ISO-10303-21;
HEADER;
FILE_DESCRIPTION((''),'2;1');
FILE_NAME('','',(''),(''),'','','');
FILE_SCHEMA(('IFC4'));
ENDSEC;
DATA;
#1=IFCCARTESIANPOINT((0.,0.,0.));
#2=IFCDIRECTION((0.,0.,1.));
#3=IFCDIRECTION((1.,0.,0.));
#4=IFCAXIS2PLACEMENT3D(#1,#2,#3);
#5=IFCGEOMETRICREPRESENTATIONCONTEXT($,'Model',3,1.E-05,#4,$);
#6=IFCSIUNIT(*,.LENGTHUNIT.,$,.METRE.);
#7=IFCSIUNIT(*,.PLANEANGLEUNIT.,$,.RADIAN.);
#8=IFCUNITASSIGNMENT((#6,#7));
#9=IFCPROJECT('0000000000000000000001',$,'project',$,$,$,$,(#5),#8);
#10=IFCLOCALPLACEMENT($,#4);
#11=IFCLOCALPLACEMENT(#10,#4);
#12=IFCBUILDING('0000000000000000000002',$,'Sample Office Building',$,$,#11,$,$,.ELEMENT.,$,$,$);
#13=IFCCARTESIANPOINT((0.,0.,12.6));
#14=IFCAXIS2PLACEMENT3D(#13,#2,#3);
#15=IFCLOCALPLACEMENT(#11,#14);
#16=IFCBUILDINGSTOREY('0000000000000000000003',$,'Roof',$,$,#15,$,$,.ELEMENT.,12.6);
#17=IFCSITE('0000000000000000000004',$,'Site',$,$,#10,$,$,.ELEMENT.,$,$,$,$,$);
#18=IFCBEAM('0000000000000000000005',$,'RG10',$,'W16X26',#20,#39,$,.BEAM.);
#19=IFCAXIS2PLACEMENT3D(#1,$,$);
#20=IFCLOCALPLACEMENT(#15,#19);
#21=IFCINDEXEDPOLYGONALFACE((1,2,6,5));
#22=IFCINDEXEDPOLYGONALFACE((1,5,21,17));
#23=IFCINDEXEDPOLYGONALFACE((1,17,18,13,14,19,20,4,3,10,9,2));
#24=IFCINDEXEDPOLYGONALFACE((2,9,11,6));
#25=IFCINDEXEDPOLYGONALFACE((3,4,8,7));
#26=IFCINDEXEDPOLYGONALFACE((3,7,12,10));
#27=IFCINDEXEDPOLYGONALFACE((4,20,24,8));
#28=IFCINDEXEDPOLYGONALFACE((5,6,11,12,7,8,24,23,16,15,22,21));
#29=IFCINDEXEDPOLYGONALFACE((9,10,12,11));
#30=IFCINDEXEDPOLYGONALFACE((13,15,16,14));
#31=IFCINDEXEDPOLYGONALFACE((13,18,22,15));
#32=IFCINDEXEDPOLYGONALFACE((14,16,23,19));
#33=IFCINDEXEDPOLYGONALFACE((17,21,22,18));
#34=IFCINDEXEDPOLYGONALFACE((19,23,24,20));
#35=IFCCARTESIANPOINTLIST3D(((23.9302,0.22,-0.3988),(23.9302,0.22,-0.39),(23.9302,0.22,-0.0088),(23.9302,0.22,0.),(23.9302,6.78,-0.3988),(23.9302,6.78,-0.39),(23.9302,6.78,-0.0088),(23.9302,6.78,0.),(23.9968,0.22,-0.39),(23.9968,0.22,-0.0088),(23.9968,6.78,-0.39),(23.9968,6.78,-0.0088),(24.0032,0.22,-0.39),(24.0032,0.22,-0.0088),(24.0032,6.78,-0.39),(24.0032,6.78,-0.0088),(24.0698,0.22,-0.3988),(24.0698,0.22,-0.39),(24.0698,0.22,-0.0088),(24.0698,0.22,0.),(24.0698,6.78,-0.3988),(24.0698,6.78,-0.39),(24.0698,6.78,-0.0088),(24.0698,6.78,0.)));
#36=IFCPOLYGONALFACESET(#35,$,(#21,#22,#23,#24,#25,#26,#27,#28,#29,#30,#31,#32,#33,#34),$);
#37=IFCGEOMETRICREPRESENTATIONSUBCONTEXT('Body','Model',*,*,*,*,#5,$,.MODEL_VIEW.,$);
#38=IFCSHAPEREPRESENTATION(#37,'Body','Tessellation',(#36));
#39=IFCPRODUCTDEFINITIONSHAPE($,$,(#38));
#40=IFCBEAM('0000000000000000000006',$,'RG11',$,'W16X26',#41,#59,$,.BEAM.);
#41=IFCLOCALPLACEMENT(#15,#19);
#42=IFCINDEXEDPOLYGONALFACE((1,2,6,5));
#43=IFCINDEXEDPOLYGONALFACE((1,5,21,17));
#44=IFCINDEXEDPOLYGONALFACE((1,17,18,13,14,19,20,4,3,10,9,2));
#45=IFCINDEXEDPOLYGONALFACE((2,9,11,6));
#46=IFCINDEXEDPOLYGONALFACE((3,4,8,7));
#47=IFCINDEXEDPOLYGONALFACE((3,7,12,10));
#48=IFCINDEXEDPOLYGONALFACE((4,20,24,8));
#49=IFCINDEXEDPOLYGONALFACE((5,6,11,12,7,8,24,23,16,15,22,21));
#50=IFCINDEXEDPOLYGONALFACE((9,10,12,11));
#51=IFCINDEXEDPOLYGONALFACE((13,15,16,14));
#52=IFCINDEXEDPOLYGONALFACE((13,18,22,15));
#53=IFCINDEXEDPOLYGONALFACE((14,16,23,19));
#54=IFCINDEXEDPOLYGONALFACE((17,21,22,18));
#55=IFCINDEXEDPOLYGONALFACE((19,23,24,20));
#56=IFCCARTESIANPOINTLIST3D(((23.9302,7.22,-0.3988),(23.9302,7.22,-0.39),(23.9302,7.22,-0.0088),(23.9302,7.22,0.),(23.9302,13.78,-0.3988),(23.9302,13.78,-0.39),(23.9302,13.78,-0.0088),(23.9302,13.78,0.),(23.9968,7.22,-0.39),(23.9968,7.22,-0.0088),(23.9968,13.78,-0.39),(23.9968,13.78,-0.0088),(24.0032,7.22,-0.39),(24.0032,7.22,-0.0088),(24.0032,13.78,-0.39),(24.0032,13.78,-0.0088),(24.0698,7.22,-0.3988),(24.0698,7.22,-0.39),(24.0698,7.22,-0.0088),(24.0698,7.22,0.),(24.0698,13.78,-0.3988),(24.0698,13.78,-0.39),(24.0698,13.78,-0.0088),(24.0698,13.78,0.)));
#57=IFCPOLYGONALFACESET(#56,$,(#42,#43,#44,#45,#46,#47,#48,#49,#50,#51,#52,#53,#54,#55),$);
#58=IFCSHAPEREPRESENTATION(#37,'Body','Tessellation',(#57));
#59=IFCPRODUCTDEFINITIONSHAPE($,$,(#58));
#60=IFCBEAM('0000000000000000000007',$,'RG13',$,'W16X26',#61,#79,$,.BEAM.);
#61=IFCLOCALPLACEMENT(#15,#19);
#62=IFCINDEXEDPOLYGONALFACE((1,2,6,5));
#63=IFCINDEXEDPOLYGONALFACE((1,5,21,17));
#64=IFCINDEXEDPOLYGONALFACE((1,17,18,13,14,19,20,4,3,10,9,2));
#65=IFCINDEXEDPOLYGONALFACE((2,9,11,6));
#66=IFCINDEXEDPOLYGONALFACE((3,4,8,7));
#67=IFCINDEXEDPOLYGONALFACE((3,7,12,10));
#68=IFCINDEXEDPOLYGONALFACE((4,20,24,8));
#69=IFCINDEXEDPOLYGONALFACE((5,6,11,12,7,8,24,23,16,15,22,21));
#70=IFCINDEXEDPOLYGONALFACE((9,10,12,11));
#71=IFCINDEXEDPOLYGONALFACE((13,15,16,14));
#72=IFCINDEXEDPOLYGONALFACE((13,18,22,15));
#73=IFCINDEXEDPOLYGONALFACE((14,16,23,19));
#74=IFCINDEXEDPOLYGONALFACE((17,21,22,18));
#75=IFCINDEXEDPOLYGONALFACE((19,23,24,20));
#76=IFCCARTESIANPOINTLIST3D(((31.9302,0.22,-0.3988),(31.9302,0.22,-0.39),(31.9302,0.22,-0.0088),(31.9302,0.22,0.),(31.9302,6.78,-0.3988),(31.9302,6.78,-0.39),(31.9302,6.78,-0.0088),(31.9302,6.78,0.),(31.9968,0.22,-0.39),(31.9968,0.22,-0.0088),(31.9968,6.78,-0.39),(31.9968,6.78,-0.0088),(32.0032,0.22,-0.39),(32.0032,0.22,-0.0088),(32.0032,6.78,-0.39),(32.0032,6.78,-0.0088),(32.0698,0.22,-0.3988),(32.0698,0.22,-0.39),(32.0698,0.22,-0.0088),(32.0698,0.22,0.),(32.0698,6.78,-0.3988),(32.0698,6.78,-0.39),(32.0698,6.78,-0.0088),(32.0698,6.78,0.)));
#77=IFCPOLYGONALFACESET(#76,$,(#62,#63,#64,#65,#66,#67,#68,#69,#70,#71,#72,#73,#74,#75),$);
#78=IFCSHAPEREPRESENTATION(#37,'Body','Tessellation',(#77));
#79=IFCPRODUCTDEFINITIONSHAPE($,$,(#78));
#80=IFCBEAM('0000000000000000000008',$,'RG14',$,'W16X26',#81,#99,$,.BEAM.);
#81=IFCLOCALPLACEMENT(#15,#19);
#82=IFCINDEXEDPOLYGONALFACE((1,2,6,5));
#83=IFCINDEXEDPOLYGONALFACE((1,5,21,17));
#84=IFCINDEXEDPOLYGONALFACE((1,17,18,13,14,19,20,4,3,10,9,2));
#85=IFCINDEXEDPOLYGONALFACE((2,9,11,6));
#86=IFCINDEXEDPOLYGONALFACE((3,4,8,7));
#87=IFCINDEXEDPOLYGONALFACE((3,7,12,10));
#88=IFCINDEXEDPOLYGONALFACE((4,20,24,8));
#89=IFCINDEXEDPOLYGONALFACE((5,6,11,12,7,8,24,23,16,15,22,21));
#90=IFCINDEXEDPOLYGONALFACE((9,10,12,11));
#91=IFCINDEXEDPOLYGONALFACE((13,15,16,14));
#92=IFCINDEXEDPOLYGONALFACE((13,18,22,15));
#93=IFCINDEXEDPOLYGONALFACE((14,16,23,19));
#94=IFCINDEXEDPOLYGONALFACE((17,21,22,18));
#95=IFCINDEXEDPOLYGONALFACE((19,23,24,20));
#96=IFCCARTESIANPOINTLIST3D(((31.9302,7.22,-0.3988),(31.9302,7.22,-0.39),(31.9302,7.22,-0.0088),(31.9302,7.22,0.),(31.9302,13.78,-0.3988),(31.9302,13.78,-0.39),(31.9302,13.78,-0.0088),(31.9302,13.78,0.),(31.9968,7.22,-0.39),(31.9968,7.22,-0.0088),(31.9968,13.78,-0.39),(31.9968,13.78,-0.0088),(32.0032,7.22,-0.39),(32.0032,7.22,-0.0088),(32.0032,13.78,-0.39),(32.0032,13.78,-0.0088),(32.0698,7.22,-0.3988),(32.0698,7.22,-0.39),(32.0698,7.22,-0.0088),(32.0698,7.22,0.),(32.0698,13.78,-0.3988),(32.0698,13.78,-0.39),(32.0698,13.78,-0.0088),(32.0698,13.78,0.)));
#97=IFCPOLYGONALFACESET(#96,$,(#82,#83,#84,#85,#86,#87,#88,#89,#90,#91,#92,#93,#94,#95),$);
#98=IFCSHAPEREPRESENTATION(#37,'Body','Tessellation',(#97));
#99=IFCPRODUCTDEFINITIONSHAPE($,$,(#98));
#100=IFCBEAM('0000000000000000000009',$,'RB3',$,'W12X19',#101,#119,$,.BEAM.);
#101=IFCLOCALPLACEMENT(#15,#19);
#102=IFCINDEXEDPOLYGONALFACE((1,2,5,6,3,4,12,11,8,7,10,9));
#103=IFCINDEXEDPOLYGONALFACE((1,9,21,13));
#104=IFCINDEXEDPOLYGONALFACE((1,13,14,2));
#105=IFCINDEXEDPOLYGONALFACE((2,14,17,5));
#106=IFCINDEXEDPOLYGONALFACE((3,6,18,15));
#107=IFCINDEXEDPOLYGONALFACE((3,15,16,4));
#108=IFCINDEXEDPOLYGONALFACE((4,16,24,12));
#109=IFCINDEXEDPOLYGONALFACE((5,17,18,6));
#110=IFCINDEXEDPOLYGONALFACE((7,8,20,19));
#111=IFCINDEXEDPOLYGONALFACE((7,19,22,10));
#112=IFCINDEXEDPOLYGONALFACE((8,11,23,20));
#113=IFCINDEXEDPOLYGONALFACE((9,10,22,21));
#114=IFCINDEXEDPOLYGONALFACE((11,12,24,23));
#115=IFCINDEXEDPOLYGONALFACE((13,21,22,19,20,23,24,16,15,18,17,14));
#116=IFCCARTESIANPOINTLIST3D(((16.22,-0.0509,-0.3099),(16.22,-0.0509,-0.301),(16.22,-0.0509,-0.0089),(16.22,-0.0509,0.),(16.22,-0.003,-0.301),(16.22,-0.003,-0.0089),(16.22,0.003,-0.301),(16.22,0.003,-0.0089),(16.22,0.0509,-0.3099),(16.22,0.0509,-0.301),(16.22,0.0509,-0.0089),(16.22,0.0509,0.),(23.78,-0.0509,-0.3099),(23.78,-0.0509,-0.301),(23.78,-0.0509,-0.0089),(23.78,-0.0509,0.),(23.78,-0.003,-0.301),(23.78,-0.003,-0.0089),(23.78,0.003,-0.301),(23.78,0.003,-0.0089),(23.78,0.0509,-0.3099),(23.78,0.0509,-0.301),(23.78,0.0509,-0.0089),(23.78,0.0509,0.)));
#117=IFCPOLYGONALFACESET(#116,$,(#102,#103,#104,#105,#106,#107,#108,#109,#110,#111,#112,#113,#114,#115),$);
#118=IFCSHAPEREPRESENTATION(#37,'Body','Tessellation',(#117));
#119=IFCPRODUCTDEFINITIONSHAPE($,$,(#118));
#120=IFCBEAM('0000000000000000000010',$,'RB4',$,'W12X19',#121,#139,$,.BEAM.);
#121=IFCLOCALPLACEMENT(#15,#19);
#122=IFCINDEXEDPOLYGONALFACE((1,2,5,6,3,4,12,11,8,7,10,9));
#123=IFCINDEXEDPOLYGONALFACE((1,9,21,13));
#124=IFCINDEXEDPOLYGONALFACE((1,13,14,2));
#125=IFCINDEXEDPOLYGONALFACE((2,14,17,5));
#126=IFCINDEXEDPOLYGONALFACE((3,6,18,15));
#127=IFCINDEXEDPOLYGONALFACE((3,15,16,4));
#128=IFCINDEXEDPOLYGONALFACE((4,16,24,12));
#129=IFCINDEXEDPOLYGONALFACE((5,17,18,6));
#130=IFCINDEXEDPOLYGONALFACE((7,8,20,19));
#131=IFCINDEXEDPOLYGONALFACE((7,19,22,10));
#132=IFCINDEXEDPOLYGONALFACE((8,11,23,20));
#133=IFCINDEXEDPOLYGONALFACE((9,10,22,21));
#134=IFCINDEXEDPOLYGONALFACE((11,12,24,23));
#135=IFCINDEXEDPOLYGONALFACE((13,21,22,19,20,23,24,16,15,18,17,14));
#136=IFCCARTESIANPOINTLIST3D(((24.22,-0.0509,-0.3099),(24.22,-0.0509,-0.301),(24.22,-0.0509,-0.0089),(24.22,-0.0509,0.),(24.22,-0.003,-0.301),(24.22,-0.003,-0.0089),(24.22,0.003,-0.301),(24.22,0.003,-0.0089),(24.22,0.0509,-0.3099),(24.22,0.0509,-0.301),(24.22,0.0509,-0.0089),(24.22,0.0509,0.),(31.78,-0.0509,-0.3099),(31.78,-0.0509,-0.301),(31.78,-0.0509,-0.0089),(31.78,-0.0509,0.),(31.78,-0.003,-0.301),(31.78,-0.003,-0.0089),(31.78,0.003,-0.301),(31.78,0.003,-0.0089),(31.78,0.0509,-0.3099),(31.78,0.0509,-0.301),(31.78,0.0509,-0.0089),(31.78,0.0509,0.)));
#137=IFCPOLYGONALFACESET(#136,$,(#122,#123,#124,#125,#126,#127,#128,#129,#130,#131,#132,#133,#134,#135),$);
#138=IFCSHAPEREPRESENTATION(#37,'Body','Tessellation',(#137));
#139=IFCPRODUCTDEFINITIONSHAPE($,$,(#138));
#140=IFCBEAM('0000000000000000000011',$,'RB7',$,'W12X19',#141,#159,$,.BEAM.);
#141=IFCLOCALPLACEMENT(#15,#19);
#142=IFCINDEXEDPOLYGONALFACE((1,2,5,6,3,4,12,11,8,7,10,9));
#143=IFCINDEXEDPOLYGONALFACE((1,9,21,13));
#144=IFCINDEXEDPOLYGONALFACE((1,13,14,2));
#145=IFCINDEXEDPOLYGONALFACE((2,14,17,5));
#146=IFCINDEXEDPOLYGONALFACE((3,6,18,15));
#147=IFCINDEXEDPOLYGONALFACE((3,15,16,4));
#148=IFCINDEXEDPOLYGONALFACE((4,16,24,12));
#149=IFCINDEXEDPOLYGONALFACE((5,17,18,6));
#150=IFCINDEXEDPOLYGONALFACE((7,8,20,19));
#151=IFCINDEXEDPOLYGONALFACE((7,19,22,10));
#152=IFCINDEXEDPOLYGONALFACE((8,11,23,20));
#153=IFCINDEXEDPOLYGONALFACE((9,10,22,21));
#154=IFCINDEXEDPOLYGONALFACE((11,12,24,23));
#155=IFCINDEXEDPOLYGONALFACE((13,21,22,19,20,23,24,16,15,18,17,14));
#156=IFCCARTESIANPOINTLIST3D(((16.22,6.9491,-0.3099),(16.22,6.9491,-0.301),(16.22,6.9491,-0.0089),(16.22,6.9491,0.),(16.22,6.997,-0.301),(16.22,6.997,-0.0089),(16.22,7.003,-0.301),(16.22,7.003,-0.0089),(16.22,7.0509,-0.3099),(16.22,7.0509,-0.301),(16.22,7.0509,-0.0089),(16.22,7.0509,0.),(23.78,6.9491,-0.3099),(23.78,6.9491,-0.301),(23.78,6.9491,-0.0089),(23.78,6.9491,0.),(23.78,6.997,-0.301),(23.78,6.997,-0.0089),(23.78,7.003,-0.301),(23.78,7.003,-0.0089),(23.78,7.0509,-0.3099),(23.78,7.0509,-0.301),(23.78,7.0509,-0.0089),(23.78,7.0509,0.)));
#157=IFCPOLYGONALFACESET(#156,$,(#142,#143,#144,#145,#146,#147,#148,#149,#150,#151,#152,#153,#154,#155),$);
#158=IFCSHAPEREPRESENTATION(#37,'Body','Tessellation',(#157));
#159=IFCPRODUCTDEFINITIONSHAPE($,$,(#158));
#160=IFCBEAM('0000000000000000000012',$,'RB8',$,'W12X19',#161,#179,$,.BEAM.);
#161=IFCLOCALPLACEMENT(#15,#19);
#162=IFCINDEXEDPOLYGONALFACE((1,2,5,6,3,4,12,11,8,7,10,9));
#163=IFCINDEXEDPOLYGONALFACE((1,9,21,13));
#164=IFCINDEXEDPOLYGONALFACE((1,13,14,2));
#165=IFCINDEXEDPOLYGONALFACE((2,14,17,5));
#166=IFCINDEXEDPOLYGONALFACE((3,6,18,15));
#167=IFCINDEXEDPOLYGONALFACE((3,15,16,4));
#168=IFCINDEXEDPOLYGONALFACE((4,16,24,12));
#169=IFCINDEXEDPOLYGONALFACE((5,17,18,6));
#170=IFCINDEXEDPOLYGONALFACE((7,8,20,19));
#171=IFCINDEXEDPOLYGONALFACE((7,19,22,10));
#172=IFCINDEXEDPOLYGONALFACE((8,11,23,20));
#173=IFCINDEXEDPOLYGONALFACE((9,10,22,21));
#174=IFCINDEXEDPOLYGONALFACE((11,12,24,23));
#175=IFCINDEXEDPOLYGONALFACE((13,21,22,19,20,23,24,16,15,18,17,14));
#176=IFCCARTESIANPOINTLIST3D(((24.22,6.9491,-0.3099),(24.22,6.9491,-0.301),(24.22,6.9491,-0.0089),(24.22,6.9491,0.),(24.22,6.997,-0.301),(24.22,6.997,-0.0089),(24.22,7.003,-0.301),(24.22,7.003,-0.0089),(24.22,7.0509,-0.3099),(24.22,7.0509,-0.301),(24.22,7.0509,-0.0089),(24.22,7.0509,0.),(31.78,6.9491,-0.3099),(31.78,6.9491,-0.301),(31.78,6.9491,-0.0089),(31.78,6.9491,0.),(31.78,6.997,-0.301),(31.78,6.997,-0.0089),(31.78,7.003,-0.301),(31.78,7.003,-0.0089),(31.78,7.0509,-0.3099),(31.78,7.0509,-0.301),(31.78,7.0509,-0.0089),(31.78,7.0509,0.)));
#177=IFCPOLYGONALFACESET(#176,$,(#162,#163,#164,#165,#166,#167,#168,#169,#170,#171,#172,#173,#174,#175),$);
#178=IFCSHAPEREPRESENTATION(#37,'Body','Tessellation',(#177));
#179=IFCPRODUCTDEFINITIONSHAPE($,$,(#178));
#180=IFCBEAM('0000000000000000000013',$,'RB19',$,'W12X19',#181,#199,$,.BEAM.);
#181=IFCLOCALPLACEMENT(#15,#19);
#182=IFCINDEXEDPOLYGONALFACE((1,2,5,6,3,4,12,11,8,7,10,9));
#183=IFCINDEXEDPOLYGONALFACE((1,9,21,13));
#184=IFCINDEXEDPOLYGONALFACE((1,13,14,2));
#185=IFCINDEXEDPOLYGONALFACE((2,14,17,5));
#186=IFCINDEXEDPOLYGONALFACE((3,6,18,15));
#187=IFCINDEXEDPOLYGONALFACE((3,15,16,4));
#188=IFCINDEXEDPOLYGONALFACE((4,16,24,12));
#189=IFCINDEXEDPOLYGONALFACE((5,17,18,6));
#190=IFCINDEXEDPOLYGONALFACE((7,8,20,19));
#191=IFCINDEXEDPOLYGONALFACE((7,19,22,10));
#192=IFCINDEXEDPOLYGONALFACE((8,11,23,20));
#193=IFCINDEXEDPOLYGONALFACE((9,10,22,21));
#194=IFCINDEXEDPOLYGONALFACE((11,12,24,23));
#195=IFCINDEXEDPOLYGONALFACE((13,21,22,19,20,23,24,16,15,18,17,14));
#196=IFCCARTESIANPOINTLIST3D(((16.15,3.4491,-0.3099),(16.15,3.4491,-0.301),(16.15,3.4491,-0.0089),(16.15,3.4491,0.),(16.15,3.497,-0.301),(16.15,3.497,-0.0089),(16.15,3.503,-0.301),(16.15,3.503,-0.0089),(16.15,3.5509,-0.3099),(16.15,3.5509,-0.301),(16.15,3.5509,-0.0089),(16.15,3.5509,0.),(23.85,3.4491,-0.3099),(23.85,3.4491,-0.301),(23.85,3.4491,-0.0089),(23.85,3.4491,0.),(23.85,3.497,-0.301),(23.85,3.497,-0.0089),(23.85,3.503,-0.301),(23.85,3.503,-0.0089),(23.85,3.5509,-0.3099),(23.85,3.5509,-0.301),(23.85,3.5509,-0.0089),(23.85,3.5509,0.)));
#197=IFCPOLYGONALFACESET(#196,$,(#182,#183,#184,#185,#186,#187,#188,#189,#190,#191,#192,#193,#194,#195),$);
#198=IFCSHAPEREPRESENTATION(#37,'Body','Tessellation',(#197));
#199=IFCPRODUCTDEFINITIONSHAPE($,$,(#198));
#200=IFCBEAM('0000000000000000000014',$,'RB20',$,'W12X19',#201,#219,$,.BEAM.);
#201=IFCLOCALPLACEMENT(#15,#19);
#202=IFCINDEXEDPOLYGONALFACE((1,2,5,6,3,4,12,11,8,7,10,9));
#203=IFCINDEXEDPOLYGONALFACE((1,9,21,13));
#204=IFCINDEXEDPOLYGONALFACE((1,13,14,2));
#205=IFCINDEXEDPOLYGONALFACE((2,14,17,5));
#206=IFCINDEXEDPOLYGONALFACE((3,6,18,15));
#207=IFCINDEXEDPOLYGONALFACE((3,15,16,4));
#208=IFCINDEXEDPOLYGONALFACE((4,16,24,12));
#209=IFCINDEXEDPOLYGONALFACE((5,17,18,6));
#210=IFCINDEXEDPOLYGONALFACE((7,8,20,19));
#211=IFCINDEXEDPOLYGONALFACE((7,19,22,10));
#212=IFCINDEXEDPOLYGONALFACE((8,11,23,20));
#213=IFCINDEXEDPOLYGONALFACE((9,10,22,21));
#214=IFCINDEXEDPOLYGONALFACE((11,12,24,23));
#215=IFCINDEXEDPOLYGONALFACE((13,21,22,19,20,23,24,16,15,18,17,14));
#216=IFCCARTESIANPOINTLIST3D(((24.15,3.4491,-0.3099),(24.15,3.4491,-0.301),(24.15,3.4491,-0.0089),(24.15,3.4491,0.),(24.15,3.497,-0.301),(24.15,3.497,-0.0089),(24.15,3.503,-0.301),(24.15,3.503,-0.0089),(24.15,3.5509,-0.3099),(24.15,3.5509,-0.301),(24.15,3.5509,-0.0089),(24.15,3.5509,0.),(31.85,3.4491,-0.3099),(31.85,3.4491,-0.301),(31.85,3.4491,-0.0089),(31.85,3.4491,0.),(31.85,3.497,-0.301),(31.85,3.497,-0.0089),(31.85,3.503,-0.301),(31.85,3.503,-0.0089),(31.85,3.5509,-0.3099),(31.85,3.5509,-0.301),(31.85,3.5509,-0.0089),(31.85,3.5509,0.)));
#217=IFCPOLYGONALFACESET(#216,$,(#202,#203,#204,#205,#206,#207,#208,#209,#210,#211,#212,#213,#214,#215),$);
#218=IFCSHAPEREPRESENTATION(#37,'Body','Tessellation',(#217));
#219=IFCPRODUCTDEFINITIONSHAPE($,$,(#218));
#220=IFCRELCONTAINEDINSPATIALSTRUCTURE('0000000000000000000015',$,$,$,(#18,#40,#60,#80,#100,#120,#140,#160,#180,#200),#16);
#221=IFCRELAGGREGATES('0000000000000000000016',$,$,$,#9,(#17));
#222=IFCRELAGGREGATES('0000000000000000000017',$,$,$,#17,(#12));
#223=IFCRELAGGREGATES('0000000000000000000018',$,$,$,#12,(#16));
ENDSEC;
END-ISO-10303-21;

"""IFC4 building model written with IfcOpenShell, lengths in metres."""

from ifc_helpers import new_model, si_unit, frame, origin_with_axes, place, context, subcontext, project, spatial, i_section, extrude, element, save


model = new_model("IFC4")

# Units and contexts
model_context = context("Model", 3, precision=1e-05, world=origin_with_axes())
body_context = subcontext(model_context, "Body", "Model", "MODEL_VIEW")
ifc_project = project(units=[si_unit("LENGTHUNIT", "METRE"), si_unit("PLANEANGLEUNIT", "RADIAN")], contexts=[model_context])

# Site, building, storey
site_placement = place(None, origin_with_axes())
site = spatial("IfcSite", under=ifc_project, at=site_placement, Name="Site", CompositionType="ELEMENT")
building_placement = place(site_placement, origin_with_axes())
building = spatial("IfcBuilding", under=site, at=building_placement, Name="Sample Office Building", CompositionType="ELEMENT")
storey_placement = place(building_placement, frame((0.0, 0.0, 12.6), z_axis=(0.0, 0.0, 1.0), x_axis=(1.0, 0.0, 0.0)))
storey = spatial("IfcBuildingStorey", under=building, at=storey_placement, Name="Roof", CompositionType="ELEMENT", Elevation=12.6)

# Beams
beam_1_placement = place(None, frame((24.0, 0.22, 12.4006), z_axis=(0.0, 1.0, 0.0), x_axis=(-1.0, 0.0, 0.0)))
element("IfcBeam", 1, at=beam_1_placement, inside=storey, Name="RG10", ObjectType="W16X26", PredefinedType="BEAM", context=body_context, shape_type="SweptSolid", body=[
    extrude(i_section(OverallWidth=0.1397, OverallDepth=0.3988, WebThickness=0.0063, FlangeThickness=0.0088), None, (0.0, 0.0, 1.0), 6.56),
])
beam_2_placement = place(None, frame((24.0, 7.22, 12.4006), z_axis=(0.0, 1.0, 0.0), x_axis=(-1.0, 0.0, 0.0)))
element("IfcBeam", 2, at=beam_2_placement, inside=storey, Name="RG11", ObjectType="W16X26", PredefinedType="BEAM", context=body_context, shape_type="SweptSolid", body=[
    extrude(i_section(OverallWidth=0.1397, OverallDepth=0.3988, WebThickness=0.0063, FlangeThickness=0.0088), None, (0.0, 0.0, 1.0), 6.56),
])
beam_3_placement = place(None, frame((32.0, 0.22, 12.4006), z_axis=(0.0, 1.0, 0.0), x_axis=(-1.0, 0.0, 0.0)))
element("IfcBeam", 3, at=beam_3_placement, inside=storey, Name="RG13", ObjectType="W16X26", PredefinedType="BEAM", context=body_context, shape_type="SweptSolid", body=[
    extrude(i_section(OverallWidth=0.1397, OverallDepth=0.3988, WebThickness=0.0063, FlangeThickness=0.0088), None, (0.0, 0.0, 1.0), 6.56),
])
beam_4_placement = place(None, frame((32.0, 7.22, 12.4006), z_axis=(0.0, 1.0, 0.0), x_axis=(-1.0, 0.0, 0.0)))
element("IfcBeam", 4, at=beam_4_placement, inside=storey, Name="RG14", ObjectType="W16X26", PredefinedType="BEAM", context=body_context, shape_type="SweptSolid", body=[
    extrude(i_section(OverallWidth=0.1397, OverallDepth=0.3988, WebThickness=0.0063, FlangeThickness=0.0088), None, (0.0, 0.0, 1.0), 6.56),
])
for number, where, z_axis, x_axis, name in (
    (5, (16.22, 0.0, 12.4451), (1.0, 0.0, 0.0), (0.0, 1.0, 0.0), "RB3"),
    (6, (24.22, 0.0, 12.4451), (1.0, 0.0, 0.0), (0.0, 1.0, 0.0), "RB4"),
    (7, (16.22, 7.0, 12.4451), (1.0, 0.0, 0.0), (0.0, 1.0, 0.0), "RB7"),
    (8, (24.22, 7.0, 12.4451), (1.0, 0.0, 0.0), (0.0, 1.0, 0.0), "RB8"),
):
    element("IfcBeam", number, at=place(None, frame(where, z_axis=z_axis, x_axis=x_axis)), inside=storey, Name=name, ObjectType="W12X19", PredefinedType="BEAM", context=body_context, shape_type="SweptSolid", body=[
        extrude(i_section(OverallWidth=0.1019, OverallDepth=0.3099, WebThickness=0.006, FlangeThickness=0.0089), None, (0.0, 0.0, 1.0), 7.56),
    ])
for number, where, z_axis, x_axis, name in (
    (9, (16.15, 3.5, 12.4451), (1.0, 0.0, 0.0), (0.0, 1.0, 0.0), "RB19"),
    (10, (24.15, 3.5, 12.4451), (1.0, 0.0, 0.0), (0.0, 1.0, 0.0), "RB20"),
):
    element("IfcBeam", number, at=place(None, frame(where, z_axis=z_axis, x_axis=x_axis)), inside=storey, Name=name, ObjectType="W12X19", PredefinedType="BEAM", context=body_context, shape_type="SweptSolid", body=[
        extrude(i_section(OverallWidth=0.1019, OverallDepth=0.3099, WebThickness=0.006, FlangeThickness=0.0089), None, (0.0, 0.0, 1.0), 7.7),
    ])

save(model, "model.ifc")
